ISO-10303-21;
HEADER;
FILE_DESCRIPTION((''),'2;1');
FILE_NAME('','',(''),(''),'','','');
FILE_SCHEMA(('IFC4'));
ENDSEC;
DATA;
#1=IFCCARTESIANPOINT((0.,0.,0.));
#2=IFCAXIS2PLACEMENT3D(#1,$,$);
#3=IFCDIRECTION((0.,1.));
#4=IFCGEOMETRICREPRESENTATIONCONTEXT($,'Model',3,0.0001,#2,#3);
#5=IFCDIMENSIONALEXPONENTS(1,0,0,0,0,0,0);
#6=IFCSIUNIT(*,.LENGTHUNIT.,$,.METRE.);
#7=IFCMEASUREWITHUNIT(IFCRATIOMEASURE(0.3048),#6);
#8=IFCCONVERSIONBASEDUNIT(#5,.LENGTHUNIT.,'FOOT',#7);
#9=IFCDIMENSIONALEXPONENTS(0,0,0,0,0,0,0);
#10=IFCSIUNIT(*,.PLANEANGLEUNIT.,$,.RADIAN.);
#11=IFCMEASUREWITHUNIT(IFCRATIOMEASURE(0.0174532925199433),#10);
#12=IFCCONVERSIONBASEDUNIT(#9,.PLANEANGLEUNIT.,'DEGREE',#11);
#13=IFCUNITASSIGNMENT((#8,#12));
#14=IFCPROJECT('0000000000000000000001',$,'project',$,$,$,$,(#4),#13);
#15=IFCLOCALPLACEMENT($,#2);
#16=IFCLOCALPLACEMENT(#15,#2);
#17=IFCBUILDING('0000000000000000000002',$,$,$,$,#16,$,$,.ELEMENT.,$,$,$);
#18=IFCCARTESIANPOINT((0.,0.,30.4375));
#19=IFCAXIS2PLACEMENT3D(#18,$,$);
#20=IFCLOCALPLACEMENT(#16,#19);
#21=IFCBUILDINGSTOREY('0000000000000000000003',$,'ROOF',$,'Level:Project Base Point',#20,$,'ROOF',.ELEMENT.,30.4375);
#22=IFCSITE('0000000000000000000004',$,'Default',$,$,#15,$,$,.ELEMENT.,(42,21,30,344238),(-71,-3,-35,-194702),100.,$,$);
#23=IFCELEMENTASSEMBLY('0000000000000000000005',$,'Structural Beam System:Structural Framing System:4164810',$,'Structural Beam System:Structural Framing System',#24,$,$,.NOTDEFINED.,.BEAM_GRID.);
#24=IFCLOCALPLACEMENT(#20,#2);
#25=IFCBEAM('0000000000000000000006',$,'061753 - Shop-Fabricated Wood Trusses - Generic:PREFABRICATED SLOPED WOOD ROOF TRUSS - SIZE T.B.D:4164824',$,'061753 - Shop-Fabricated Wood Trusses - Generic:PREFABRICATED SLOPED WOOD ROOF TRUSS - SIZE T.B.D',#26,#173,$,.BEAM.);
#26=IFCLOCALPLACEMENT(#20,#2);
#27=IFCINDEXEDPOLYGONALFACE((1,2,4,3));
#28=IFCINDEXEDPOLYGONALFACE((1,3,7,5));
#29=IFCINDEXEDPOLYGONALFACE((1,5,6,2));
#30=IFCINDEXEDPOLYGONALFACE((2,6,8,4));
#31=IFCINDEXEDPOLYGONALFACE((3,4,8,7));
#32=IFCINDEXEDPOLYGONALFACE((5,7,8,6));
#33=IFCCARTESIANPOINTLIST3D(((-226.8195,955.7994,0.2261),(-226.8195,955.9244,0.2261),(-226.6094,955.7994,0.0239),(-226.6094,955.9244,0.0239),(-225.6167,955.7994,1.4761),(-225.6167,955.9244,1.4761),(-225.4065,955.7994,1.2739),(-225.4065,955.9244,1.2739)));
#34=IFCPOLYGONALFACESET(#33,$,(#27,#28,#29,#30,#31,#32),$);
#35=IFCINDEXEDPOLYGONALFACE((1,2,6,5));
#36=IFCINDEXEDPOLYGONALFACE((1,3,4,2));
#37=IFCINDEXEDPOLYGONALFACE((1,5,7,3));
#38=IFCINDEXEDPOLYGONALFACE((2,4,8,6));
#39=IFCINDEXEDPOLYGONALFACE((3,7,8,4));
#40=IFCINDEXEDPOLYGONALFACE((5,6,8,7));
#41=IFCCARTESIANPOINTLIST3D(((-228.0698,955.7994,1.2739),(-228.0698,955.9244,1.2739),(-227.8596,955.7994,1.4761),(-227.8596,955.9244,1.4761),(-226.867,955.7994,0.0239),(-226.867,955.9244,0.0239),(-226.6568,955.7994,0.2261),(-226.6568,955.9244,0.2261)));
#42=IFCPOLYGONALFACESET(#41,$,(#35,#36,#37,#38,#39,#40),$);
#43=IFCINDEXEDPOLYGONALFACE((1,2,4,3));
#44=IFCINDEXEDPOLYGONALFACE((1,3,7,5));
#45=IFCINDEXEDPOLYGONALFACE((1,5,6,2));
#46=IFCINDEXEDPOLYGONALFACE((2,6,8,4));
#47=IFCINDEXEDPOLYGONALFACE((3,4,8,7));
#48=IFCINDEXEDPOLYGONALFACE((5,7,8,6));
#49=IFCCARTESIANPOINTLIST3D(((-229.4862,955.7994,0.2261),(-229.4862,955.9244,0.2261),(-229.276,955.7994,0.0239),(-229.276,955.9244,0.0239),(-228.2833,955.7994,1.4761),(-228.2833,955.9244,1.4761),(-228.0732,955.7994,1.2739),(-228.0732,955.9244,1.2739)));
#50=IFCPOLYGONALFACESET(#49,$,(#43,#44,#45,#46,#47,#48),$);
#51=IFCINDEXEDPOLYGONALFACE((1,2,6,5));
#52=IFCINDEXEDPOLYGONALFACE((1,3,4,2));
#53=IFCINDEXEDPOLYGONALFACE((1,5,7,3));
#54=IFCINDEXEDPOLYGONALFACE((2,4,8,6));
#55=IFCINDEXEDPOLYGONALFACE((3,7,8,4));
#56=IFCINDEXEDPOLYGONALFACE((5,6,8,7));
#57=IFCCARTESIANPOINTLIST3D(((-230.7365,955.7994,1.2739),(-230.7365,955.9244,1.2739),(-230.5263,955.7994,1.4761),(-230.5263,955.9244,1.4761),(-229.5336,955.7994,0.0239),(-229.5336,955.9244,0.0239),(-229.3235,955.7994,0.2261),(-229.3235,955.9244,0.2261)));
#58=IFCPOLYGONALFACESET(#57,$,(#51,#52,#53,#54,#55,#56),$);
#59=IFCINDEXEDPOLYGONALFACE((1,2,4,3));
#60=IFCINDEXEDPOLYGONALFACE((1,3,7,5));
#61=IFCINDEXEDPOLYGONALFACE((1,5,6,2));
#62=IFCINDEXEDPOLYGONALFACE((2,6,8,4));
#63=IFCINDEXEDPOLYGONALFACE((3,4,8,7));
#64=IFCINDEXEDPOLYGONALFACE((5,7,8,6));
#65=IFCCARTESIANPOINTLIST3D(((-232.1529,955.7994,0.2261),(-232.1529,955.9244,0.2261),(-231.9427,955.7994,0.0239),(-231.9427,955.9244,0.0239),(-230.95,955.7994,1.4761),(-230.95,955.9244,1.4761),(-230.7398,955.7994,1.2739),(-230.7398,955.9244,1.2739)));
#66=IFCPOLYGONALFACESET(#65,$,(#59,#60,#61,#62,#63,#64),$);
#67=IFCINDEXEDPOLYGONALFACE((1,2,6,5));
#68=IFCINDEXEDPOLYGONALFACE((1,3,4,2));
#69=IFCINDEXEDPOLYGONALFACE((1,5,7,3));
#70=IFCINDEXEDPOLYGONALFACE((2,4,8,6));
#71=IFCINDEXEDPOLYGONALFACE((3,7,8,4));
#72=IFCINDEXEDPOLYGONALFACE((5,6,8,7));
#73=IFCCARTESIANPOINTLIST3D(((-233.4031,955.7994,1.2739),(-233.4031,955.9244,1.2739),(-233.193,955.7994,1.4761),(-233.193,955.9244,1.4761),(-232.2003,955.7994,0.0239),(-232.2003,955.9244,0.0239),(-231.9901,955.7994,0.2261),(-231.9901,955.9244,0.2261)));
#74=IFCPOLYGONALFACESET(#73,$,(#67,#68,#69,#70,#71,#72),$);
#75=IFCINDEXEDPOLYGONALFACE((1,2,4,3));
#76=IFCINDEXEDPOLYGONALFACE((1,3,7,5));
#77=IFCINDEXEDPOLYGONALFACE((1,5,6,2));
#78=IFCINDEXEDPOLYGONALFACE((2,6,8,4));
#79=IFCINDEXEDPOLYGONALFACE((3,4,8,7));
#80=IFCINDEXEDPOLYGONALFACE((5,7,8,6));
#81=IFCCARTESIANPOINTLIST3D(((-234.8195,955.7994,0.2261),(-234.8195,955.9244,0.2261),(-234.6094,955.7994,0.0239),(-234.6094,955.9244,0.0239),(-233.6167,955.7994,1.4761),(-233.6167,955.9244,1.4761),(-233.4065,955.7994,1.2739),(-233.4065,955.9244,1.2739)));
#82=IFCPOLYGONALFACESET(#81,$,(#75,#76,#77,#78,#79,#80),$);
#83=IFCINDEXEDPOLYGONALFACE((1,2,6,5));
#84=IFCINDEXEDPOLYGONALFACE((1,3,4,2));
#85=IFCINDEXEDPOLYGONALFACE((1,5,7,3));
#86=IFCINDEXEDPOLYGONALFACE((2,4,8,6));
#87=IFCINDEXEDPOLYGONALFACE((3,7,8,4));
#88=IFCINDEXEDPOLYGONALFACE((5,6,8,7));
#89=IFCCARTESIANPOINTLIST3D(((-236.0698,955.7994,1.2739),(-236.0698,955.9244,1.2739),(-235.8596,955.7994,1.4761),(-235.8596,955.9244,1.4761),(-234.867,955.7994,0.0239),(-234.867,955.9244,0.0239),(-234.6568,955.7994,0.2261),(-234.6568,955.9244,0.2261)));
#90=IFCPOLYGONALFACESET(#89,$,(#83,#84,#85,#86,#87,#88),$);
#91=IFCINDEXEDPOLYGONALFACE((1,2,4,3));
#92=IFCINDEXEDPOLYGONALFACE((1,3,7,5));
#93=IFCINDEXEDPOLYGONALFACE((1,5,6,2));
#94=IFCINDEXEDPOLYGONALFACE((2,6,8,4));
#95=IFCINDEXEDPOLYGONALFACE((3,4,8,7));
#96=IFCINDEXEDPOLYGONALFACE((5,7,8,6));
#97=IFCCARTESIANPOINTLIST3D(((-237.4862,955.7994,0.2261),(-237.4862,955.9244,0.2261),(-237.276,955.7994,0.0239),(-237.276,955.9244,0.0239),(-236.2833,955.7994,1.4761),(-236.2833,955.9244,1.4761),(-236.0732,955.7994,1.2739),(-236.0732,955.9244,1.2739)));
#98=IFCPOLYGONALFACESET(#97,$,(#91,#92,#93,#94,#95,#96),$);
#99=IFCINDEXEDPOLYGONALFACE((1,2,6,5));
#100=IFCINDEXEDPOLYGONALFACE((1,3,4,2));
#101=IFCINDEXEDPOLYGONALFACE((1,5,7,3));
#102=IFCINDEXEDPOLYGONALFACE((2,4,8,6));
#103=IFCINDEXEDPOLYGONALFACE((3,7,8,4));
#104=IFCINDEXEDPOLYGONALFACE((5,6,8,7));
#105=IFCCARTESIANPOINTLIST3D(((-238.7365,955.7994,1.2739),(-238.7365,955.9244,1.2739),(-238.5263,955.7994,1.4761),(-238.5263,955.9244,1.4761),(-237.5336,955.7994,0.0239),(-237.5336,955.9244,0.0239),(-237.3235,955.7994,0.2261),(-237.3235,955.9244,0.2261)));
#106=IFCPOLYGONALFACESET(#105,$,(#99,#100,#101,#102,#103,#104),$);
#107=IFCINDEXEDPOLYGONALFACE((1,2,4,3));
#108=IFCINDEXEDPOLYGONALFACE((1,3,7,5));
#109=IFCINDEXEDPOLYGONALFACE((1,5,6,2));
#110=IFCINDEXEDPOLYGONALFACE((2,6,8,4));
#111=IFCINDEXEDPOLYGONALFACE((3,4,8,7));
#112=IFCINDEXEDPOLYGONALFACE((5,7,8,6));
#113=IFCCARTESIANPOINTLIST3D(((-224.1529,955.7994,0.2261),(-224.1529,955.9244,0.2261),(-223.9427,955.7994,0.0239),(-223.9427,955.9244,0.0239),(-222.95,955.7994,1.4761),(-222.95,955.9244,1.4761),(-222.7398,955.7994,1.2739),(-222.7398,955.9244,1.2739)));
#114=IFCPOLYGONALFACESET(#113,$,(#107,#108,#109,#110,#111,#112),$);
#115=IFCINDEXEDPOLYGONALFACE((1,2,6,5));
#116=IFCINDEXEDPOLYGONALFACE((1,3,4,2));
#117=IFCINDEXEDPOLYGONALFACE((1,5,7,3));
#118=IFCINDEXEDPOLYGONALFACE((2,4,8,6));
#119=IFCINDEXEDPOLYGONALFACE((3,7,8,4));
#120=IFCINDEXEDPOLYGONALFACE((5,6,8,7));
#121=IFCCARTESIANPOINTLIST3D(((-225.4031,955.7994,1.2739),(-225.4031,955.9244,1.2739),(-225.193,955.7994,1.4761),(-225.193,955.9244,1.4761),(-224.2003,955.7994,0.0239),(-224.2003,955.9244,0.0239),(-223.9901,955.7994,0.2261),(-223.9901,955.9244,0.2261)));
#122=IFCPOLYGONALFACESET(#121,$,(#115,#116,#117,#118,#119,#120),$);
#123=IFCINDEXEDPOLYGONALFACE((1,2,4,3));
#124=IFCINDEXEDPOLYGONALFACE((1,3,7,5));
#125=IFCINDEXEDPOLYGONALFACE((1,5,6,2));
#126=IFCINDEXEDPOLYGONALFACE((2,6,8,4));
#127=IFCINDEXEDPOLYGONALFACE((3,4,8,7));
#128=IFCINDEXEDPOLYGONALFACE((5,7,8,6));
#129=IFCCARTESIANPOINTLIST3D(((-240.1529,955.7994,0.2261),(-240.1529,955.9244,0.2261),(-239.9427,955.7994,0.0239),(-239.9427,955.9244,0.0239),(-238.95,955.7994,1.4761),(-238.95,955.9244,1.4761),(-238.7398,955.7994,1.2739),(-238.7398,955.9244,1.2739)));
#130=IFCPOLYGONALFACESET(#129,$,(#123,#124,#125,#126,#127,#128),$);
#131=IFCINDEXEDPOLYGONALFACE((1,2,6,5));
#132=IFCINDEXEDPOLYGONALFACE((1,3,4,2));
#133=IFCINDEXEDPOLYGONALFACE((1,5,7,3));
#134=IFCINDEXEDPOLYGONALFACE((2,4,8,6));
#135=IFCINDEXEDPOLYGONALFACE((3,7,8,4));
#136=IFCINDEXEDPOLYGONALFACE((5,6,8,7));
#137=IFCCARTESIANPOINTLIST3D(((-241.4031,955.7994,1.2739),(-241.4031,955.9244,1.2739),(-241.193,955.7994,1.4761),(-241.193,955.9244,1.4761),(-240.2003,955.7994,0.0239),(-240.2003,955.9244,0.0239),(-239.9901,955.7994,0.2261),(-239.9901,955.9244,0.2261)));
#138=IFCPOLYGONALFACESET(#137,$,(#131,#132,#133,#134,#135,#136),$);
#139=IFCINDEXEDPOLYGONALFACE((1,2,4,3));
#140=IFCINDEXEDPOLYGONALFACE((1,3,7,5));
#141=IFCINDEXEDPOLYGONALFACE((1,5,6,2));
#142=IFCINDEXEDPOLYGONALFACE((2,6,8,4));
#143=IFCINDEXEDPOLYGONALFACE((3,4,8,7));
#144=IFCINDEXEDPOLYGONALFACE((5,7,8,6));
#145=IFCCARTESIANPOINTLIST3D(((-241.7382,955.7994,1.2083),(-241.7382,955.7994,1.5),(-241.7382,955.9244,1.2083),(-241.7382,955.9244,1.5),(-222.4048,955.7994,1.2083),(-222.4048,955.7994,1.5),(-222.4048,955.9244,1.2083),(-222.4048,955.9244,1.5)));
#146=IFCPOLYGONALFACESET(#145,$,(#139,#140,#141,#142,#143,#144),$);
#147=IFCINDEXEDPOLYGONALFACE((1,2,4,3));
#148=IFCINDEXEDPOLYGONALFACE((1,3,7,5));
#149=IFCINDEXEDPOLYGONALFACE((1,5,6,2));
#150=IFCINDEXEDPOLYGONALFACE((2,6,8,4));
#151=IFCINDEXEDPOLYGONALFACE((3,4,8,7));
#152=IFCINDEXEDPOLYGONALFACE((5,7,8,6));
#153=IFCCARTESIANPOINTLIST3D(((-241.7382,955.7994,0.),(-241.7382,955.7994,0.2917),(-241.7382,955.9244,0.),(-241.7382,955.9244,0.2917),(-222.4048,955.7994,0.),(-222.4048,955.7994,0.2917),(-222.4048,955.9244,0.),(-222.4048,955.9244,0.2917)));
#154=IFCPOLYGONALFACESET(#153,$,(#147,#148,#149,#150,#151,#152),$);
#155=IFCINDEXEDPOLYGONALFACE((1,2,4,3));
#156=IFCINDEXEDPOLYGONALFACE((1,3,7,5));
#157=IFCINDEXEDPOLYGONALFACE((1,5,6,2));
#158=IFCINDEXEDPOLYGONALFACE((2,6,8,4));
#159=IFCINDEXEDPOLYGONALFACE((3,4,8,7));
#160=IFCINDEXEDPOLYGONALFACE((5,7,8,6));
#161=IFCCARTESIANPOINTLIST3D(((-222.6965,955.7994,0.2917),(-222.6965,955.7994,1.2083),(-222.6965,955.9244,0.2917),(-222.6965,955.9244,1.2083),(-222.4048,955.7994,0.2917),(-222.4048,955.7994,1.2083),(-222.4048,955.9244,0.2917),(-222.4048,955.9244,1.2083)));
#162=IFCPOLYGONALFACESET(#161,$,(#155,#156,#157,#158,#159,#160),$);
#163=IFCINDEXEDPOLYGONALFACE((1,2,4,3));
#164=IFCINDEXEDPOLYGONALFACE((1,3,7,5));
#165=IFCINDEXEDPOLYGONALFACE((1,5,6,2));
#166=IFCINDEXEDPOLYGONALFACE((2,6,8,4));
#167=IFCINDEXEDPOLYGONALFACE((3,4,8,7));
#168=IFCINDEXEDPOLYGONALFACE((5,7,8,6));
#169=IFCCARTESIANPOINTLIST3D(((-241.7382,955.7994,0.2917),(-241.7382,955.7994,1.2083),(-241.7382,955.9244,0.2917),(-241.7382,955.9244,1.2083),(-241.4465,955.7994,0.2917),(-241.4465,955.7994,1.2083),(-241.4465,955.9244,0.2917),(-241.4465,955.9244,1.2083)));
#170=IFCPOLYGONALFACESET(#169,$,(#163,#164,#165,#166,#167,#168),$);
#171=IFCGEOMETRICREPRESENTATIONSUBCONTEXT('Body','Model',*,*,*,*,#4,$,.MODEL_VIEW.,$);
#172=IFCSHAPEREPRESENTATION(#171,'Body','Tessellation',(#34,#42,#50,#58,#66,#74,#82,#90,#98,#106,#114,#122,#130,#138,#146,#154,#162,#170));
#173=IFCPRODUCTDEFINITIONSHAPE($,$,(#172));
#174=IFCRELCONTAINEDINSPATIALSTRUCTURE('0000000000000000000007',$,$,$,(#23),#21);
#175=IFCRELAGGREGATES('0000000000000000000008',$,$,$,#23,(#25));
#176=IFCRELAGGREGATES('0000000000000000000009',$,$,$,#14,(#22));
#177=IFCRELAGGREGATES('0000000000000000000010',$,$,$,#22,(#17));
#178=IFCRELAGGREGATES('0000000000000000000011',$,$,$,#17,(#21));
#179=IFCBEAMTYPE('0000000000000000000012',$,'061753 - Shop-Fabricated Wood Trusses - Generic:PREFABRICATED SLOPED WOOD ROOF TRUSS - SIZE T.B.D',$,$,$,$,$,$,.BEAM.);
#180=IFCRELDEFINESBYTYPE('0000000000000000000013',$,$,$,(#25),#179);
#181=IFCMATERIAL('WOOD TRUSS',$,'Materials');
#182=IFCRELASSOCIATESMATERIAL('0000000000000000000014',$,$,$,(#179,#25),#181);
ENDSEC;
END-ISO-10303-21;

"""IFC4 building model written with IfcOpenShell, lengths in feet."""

from ifc_helpers import new_model, entity, si_unit, converted_unit, direction, frame, frame_2d, origin, origin_2d_with_axis, place, context, subcontext, project, spatial, rectangle, extrude, source, transform, mapped, material, material_profile, profile_set, profile_usage, type_object, type_shapes, element, aggregate, save


model = new_model("IFC4")

# Units and contexts
model_context = context("Model", 3, precision=0.0001, world=origin(), true_north=direction((0.0, 1.0)))
body_context = subcontext(model_context, "Body", "Model", "MODEL_VIEW")
ifc_project = project(units=[converted_unit("LENGTHUNIT", "FOOT", entity("IfcRatioMeasure", 0.3048), si_unit("LENGTHUNIT", "METRE"), dimensions=[1, 0, 0, 0, 0, 0, 0]), converted_unit("PLANEANGLEUNIT", "DEGREE", entity("IfcRatioMeasure", 0.0174532925199433), si_unit("PLANEANGLEUNIT", "RADIAN"), dimensions=[0, 0, 0, 0, 0, 0, 0])], contexts=[model_context])

# Site, building, storey
site_placement = place(None, origin())
site = spatial("IfcSite", under=ifc_project, at=site_placement, Name="Default", CompositionType="ELEMENT", RefLatitude=(42, 21, 30, 344238), RefLongitude=(-71, -3, -35, -194702), RefElevation=100.0)
building_placement = place(site_placement, origin())
building = spatial("IfcBuilding", under=site, at=building_placement, CompositionType="ELEMENT")
storey_placement = place(building_placement, frame((0.0, 0.0, 30.4375)))
storey = spatial("IfcBuildingStorey", under=building, at=storey_placement, Name="ROOF", ObjectType="Level:Project Base Point", LongName="ROOF", CompositionType="ELEMENT", Elevation=30.4375)

# Element assembly, beam
assembly_1_placement = place(storey_placement, origin())
assembly_1 = element("IfcElementAssembly", 1, at=assembly_1_placement, inside=storey, Name="Structural Beam System:Structural Framing System:4164810", ObjectType="Structural Beam System:Structural Framing System", AssemblyPlace="NOTDEFINED", PredefinedType="BEAM_GRID")
ifc_material_1 = material(Name="WOOD TRUSS", Category="Materials")
ifc_material_profile_1 = material_profile(ifc_material_1, rectangle(XDim=1.7347, YDim=0.125, at=origin_2d_with_axis()), Name="PREFABRICATED SLOPED WOOD ROOF TRUSS - SIZE T.B.D")
ifc_material_profile_2 = material_profile(ifc_material_1, rectangle(XDim=1.7347, YDim=0.125, at=frame_2d((0.0, 0.0), x_axis=(1.0, 0.0))), Name="PREFABRICATED SLOPED WOOD ROOF TRUSS - SIZE T.B.D")
ifc_material_profile_3 = material_profile(ifc_material_1, rectangle(XDim=1.7347, YDim=0.125, at=origin_2d_with_axis()), Name="PREFABRICATED SLOPED WOOD ROOF TRUSS - SIZE T.B.D")
ifc_material_profile_4 = material_profile(ifc_material_1, rectangle(XDim=1.7347, YDim=0.125, at=origin_2d_with_axis()), Name="PREFABRICATED SLOPED WOOD ROOF TRUSS - SIZE T.B.D")
ifc_material_profile_5 = material_profile(ifc_material_1, rectangle(XDim=1.7347, YDim=0.125, at=frame_2d((0.0, 0.0), x_axis=(1.0, 0.0))), Name="PREFABRICATED SLOPED WOOD ROOF TRUSS - SIZE T.B.D")
ifc_material_profile_6 = material_profile(ifc_material_1, rectangle(XDim=1.7347, YDim=0.125, at=frame_2d((0.0, 0.0), x_axis=(1.0, 0.0))), Name="PREFABRICATED SLOPED WOOD ROOF TRUSS - SIZE T.B.D")
ifc_material_profile_7 = material_profile(ifc_material_1, rectangle(XDim=1.7347, YDim=0.125, at=frame_2d((0.0, 0.0), x_axis=(1.0, 0.0))), Name="PREFABRICATED SLOPED WOOD ROOF TRUSS - SIZE T.B.D")
ifc_material_profile_8 = material_profile(ifc_material_1, rectangle(XDim=1.7347, YDim=0.125, at=frame_2d((0.0, 0.0), x_axis=(1.0, 0.0))), Name="PREFABRICATED SLOPED WOOD ROOF TRUSS - SIZE T.B.D")
ifc_material_profile_9 = material_profile(ifc_material_1, rectangle(XDim=1.7347, YDim=0.125, at=origin_2d_with_axis()), Name="PREFABRICATED SLOPED WOOD ROOF TRUSS - SIZE T.B.D")
ifc_material_profile_10 = material_profile(ifc_material_1, rectangle(XDim=1.7347, YDim=0.125, at=frame_2d((0.0, 0.0), x_axis=(1.0, 0.0))), Name="PREFABRICATED SLOPED WOOD ROOF TRUSS - SIZE T.B.D")
ifc_material_profile_11 = material_profile(ifc_material_1, rectangle(XDim=0.2917, YDim=0.125, at=frame_2d((0.0, 0.0), x_axis=(1.0, 0.0))), Name="PREFABRICATED SLOPED WOOD ROOF TRUSS - SIZE T.B.D")
ifc_material_profile_12 = material_profile(ifc_material_1, rectangle(XDim=0.2917, YDim=0.125, at=frame_2d((0.0, 0.0), x_axis=(1.0, 0.0))), Name="PREFABRICATED SLOPED WOOD ROOF TRUSS - SIZE T.B.D")
ifc_material_profile_13 = material_profile(ifc_material_1, rectangle(XDim=0.9167, YDim=0.125, at=frame_2d((0.0, 0.0), x_axis=(1.0, 0.0))), Name="PREFABRICATED SLOPED WOOD ROOF TRUSS - SIZE T.B.D")
ifc_material_profile_14 = material_profile(ifc_material_1, rectangle(XDim=0.9167, YDim=0.125, at=frame_2d((0.0, 0.0), x_axis=(1.0, 0.0))), Name="PREFABRICATED SLOPED WOOD ROOF TRUSS - SIZE T.B.D")
ifc_profile_set_1 = profile_set([ifc_material_profile_1, ifc_material_profile_2, ifc_material_profile_3, ifc_material_profile_4, ifc_material_profile_5, ifc_material_profile_6, ifc_material_profile_7, ifc_material_profile_8, ifc_material_profile_9, ifc_material_profile_10, ifc_material_profile_11, ifc_material_profile_12, ifc_material_profile_13, ifc_material_profile_14], Name="PREFABRICATED SLOPED WOOD ROOF TRUSS - SIZE T.B.D")
ifc_profile_usage_1 = profile_usage(ifc_profile_set_1, cardinal=8)
beam_type_1 = type_object("IfcBeamType", Name="061753 - Shop-Fabricated Wood Trusses - Generic:PREFABRICATED SLOPED WOOD ROOF TRUSS - SIZE T.B.D", PredefinedType="BEAM", material=ifc_profile_set_1)
shared_shape_1 = source(origin(), body_context, "Body", "SweptSolid", [
    extrude(rectangle(XDim=1.7347, YDim=0.125, at=frame_2d((0.0, 0.0), x_axis=(1.0, 0.0))), frame((5.8534, 0.0, 0.1011), z_axis=(0.720569, 0.0, -0.693383), x_axis=(0.693383, 0.0, 0.720569)), (0.0, 0.0, 1.0), 0.2917),
    extrude(rectangle(XDim=1.7347, YDim=0.125, at=frame_2d((0.0, 0.0), x_axis=(1.0, 0.0))), frame((4.6031, 0.0, -0.1011), z_axis=(0.720569, 0.0, 0.693383), x_axis=(0.693383, 0.0, -0.720569)), (0.0, 0.0, 1.0), 0.2917),
    extrude(rectangle(XDim=1.7347, YDim=0.125, at=frame_2d((0.0, 0.0), x_axis=(1.0, 0.0))), frame((3.1867, 0.0, 0.1011), z_axis=(0.720569, 0.0, -0.693383), x_axis=(0.693383, 0.0, 0.720569)), (0.0, 0.0, 1.0), 0.2917),
    extrude(rectangle(XDim=1.7347, YDim=0.125, at=frame_2d((0.0, 0.0), x_axis=(1.0, 0.0))), frame((1.9364, 0.0, -0.1011), z_axis=(0.720569, 0.0, 0.693383), x_axis=(0.693383, 0.0, -0.720569)), (0.0, 0.0, 1.0), 0.2917),
    extrude(rectangle(XDim=1.7347, YDim=0.125, at=frame_2d((0.0, 0.0), x_axis=(1.0, 0.0))), frame((0.5201, 0.0, 0.1011), z_axis=(0.720569, 0.0, -0.693383), x_axis=(0.693383, 0.0, 0.720569)), (0.0, 0.0, 1.0), 0.2917),
    extrude(rectangle(XDim=1.7347, YDim=0.125, at=origin_2d_with_axis()), frame((-0.7302, 0.0, -0.1011), z_axis=(0.720569, 0.0, 0.693383), x_axis=(0.693383, 0.0, -0.720569)), (0.0, 0.0, 1.0), 0.2917),
    extrude(rectangle(XDim=1.7347, YDim=0.125, at=frame_2d((0.0, 0.0), x_axis=(1.0, 0.0))), frame((-2.1466, 0.0, 0.1011), z_axis=(0.720569, 0.0, -0.693383), x_axis=(0.693383, 0.0, 0.720569)), (0.0, 0.0, 1.0), 0.2917),
    extrude(rectangle(XDim=1.7347, YDim=0.125, at=frame_2d((0.0, 0.0), x_axis=(1.0, 0.0))), frame((-3.3969, 0.0, -0.1011), z_axis=(0.720569, 0.0, 0.693383), x_axis=(0.693383, 0.0, -0.720569)), (0.0, 0.0, 1.0), 0.2917),
    extrude(rectangle(XDim=1.7347, YDim=0.125, at=origin_2d_with_axis()), frame((-4.8133, 0.0, 0.1011), z_axis=(0.720569, 0.0, -0.693383), x_axis=(0.693383, 0.0, 0.720569)), (0.0, 0.0, 1.0), 0.2917),
    extrude(rectangle(XDim=1.7347, YDim=0.125, at=frame_2d((0.0, 0.0), x_axis=(1.0, 0.0))), frame((-6.0636, 0.0, -0.1011), z_axis=(0.720569, 0.0, 0.693383), x_axis=(0.693383, 0.0, -0.720569)), (0.0, 0.0, 1.0), 0.2917),
    extrude(rectangle(XDim=1.7347, YDim=0.125, at=frame_2d((0.0, 0.0), x_axis=(1.0, 0.0))), frame((8.5201, 0.0, 0.1011), z_axis=(0.720569, 0.0, -0.693383), x_axis=(0.693383, 0.0, 0.720569)), (0.0, 0.0, 1.0), 0.2917),
    extrude(rectangle(XDim=1.7347, YDim=0.125, at=origin_2d_with_axis()), frame((7.2698, 0.0, -0.1011), z_axis=(0.720569, 0.0, 0.693383), x_axis=(0.693383, 0.0, -0.720569)), (0.0, 0.0, 1.0), 0.2917),
    extrude(rectangle(XDim=1.7347, YDim=0.125, at=frame_2d((0.0, 0.0), x_axis=(1.0, 0.0))), frame((-7.4799, 0.0, 0.1011), z_axis=(0.720569, 0.0, -0.693383), x_axis=(0.693383, 0.0, 0.720569)), (0.0, 0.0, 1.0), 0.2917),
    extrude(rectangle(XDim=1.7347, YDim=0.125, at=origin_2d_with_axis()), frame((-8.7302, 0.0, -0.1011), z_axis=(0.720569, 0.0, 0.693383), x_axis=(0.693383, 0.0, -0.720569)), (0.0, 0.0, 1.0), 0.2917),
    extrude(rectangle(XDim=0.2917, YDim=0.125, at=frame_2d((0.0, 0.0), x_axis=(1.0, 0.0))), frame((-9.6667, 0.0, 0.6042), z_axis=(1.0, 0.0, 0.0), x_axis=(0.0, 0.0, -1.0)), (0.0, 0.0, 1.0), 19.3333),
    extrude(rectangle(XDim=0.2917, YDim=0.125, at=frame_2d((0.0, 0.0), x_axis=(1.0, 0.0))), frame((-9.6667, 0.0, -0.6042), z_axis=(1.0, 0.0, 0.0), x_axis=(0.0, 0.0, -1.0)), (0.0, 0.0, 1.0), 19.3333),
    extrude(rectangle(XDim=0.9167, YDim=0.125, at=frame_2d((0.0, 0.0), x_axis=(1.0, 0.0))), frame((9.375, 0.0, 0.0), z_axis=(1.0, 0.0, 0.0), x_axis=(0.0, 0.0, -1.0)), (0.0, 0.0, 1.0), 0.2917),
    extrude(rectangle(XDim=0.9167, YDim=0.125, at=frame_2d((0.0, 0.0), x_axis=(1.0, 0.0))), frame((-9.6667, 0.0, 0.0), z_axis=(1.0, 0.0, 0.0), x_axis=(0.0, 0.0, -1.0)), (0.0, 0.0, 1.0), 0.2917),
])
type_shapes(beam_type_1, [shared_shape_1])
beam_1_placement = place(assembly_1_placement, frame((-232.0715, 955.8619, 0.75)))
beam_1 = element("IfcBeam", 2, at=beam_1_placement, type_object=beam_type_1, material=ifc_profile_usage_1, Name="061753 - Shop-Fabricated Wood Trusses - Generic:PREFABRICATED SLOPED WOOD ROOF TRUSS - SIZE T.B.D:4164824", ObjectType="061753 - Shop-Fabricated Wood Trusses - Generic:PREFABRICATED SLOPED WOOD ROOF TRUSS - SIZE T.B.D", PredefinedType="BEAM", context=body_context, shape_type="MappedRepresentation", body=[
    mapped(shared_shape_1, transform((0.0, 0.0, 0.0), scale=1.0)),
])
aggregate(assembly_1, [beam_1])

save(model, "model.ifc")
